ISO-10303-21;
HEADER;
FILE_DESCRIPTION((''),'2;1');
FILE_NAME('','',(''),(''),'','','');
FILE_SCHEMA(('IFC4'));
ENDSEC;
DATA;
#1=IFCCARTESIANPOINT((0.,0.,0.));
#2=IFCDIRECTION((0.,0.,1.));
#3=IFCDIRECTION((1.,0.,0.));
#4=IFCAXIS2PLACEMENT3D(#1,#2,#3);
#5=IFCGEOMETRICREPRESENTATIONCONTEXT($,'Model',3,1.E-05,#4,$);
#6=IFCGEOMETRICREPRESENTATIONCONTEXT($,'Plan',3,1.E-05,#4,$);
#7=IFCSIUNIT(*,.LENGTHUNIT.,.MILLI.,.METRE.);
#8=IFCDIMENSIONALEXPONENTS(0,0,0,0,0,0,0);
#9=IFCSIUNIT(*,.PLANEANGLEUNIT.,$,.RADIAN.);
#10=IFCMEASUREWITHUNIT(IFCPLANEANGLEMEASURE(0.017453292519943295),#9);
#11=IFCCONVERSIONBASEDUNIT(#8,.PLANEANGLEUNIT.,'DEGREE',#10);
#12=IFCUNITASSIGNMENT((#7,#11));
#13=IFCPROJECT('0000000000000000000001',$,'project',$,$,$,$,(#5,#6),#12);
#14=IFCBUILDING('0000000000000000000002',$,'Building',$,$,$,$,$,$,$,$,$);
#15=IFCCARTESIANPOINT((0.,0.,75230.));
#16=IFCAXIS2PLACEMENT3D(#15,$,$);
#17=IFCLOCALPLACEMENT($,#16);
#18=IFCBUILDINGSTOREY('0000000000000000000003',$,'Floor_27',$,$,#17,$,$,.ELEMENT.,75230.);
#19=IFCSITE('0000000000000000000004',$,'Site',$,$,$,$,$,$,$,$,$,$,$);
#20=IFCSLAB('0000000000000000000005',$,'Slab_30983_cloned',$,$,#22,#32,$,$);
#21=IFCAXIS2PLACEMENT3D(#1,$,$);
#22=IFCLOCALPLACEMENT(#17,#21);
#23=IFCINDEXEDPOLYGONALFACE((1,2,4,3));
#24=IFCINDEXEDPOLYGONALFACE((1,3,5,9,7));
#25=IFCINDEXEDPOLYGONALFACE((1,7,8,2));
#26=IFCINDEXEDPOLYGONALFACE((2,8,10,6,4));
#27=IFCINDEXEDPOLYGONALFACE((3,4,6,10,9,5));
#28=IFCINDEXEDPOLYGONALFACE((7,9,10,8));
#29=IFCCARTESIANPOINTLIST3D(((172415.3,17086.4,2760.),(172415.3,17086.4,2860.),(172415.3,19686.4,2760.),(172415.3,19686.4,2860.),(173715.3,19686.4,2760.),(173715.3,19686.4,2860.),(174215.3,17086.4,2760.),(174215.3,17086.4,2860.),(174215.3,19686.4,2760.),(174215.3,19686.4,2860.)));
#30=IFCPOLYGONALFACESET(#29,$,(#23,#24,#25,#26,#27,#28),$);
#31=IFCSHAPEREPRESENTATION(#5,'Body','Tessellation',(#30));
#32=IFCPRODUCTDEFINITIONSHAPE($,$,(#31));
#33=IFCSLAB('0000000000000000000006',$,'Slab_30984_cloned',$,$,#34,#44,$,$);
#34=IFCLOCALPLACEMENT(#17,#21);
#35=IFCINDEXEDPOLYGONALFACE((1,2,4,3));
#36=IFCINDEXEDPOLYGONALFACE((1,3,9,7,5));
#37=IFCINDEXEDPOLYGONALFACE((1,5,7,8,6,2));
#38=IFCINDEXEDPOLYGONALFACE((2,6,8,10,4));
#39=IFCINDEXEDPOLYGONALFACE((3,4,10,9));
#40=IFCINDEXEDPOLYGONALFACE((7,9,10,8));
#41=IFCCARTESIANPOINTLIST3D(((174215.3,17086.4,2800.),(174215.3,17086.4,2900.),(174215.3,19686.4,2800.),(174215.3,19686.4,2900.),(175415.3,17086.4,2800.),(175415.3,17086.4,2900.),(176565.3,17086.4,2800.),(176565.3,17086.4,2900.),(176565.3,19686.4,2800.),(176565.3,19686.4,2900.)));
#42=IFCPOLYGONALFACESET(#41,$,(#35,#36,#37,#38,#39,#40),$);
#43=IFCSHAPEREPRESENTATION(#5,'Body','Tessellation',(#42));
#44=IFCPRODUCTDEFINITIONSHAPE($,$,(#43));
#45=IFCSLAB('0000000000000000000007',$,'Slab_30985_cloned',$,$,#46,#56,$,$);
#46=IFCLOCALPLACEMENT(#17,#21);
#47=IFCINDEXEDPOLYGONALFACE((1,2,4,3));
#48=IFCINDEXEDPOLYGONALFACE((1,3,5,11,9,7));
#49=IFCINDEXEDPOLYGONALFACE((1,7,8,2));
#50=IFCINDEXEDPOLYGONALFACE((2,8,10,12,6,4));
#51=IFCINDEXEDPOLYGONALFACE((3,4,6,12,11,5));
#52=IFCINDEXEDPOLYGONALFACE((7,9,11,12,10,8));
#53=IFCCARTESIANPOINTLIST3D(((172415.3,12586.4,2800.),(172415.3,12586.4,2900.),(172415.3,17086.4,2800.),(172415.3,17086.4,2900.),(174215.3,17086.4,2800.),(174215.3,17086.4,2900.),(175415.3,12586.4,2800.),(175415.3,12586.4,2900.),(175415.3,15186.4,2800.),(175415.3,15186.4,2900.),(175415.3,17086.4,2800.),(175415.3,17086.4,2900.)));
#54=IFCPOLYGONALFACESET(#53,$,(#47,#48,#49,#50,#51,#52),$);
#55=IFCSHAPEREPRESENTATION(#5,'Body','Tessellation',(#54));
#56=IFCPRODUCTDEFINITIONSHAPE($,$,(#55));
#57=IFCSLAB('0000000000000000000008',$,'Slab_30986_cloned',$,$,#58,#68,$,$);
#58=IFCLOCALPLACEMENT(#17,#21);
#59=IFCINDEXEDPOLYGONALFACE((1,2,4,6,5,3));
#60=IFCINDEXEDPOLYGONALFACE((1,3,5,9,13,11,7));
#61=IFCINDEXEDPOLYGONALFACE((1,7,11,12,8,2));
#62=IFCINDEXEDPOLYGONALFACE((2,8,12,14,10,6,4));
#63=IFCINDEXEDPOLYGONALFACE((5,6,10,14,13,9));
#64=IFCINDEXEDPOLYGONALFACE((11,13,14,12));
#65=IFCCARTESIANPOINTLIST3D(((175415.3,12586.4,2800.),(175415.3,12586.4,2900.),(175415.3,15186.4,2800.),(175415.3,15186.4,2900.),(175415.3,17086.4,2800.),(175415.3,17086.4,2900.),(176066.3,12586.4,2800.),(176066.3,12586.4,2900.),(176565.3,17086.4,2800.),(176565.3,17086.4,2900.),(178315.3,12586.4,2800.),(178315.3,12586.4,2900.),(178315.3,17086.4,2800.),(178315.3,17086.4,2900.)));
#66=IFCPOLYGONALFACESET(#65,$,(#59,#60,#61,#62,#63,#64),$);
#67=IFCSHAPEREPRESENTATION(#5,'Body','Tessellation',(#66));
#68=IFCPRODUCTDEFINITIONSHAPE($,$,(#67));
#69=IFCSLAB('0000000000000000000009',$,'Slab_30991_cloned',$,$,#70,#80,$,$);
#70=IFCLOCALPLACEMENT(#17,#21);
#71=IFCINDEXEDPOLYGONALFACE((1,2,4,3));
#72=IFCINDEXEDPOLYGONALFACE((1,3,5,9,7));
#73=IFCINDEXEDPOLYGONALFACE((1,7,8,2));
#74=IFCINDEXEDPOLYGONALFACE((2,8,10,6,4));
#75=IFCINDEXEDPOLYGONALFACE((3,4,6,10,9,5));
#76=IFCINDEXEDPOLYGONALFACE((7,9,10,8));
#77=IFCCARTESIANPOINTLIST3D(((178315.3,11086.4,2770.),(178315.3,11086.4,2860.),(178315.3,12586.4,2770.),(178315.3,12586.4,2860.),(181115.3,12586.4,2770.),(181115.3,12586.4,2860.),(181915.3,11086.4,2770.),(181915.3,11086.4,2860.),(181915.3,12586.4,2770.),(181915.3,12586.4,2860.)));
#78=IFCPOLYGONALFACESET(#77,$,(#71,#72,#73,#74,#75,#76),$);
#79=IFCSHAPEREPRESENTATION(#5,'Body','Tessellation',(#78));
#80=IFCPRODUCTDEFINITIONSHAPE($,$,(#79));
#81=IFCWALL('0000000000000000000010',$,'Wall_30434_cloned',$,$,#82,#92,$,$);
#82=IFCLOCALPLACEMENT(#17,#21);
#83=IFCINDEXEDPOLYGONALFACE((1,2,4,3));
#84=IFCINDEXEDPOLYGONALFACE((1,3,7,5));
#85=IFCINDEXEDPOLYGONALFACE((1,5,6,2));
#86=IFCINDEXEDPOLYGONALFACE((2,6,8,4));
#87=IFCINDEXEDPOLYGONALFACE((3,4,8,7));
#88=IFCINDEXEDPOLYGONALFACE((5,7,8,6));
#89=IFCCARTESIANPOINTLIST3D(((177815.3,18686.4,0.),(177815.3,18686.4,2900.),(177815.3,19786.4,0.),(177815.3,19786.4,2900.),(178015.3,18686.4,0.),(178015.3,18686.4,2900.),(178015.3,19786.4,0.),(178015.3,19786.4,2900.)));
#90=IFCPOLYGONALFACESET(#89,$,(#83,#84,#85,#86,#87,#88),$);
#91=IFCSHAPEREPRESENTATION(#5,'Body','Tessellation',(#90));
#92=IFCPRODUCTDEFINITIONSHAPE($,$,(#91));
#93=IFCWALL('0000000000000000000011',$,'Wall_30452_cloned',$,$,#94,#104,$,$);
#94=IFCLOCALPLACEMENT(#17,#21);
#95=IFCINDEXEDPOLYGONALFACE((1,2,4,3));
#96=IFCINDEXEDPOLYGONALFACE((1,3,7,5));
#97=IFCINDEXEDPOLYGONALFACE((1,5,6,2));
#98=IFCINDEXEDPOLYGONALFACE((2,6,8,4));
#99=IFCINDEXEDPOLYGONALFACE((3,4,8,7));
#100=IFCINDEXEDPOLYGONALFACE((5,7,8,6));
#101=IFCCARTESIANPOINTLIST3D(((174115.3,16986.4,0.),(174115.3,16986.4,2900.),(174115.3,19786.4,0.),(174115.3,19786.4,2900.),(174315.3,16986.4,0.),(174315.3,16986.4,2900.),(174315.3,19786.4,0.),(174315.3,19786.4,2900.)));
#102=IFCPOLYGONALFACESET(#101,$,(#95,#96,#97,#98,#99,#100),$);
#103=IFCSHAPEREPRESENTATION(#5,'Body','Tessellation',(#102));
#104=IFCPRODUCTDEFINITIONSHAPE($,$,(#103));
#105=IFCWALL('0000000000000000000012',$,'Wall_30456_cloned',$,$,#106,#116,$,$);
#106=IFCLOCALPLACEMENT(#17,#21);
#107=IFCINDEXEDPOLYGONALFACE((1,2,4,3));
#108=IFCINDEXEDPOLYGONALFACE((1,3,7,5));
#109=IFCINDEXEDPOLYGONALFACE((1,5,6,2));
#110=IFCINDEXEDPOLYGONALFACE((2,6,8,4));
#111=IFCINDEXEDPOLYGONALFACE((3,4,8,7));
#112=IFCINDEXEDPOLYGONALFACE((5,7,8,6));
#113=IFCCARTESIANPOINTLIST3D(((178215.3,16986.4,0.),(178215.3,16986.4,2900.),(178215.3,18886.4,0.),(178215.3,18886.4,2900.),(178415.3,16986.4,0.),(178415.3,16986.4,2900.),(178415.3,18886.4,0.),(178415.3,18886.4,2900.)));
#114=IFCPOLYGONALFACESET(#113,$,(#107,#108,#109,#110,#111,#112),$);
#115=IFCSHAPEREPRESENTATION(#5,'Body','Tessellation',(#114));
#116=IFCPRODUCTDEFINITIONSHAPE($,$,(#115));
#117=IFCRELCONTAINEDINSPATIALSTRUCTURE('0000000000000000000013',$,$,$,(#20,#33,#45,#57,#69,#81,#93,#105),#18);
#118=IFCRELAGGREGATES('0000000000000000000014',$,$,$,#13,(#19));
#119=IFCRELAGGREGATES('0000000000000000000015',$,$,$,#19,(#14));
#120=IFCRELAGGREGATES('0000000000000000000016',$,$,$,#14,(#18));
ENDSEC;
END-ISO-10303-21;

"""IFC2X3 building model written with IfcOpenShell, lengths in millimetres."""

from ifc_helpers import new_model, entity, si_unit, converted_unit, frame, origin_with_axes, origin_2d, place, context, project, spatial, polyline, rectangle, outline, extrude, source, transform, mapped, element, save


model = new_model("IFC2X3")

# Units and contexts
model_context = context("Model", 3, precision=1e-05, world=origin_with_axes())
plan_context = context("Plan", 3, precision=1e-05, world=origin_with_axes())
ifc_project = project(units=[si_unit("LENGTHUNIT", "METRE", prefix="MILLI"), converted_unit("PLANEANGLEUNIT", "DEGREE", entity("IfcPlaneAngleMeasure", 0.017453292519943295), si_unit("PLANEANGLEUNIT", "RADIAN"), dimensions=[0, 0, 0, 0, 0, 0, 0])], contexts=[model_context, plan_context])

# Site, building, storey
site = spatial("IfcSite", under=ifc_project, Name="Site")
building = spatial("IfcBuilding", under=site, Name="Building")
storey_placement = place(None, frame((0.0, 0.0, 75230.0)))
storey = spatial("IfcBuildingStorey", under=building, at=storey_placement, Name="Floor_27", CompositionType="ELEMENT", Elevation=75230.0)

# Slabs
shared_shape_1 = source(origin_with_axes(), model_context, "Body", "SweptSolid", [
    extrude(outline(polyline([(0.0, 0.0), (2600.0, 0.0), (2600.0, 1800.0), (0.0, 1800.0), (0.0, 1300.0)])), origin_with_axes(), (0.0, 0.0, 1.0), 100.0),
])
slab_1_placement = place(storey_placement, frame((172415.3, 19686.4, 2760.0), z_axis=(0.0, 0.0, 1.0), x_axis=(0.0, -2599.99, 0.0)))
element("IfcSlab", 1, at=slab_1_placement, inside=storey, Name="Slab_30983_cloned", context=model_context, shape_type="MappedRepresentation", body=[
    mapped(shared_shape_1, transform((0.0, 0.0, 0.0), x_axis=(1.0, 0.0, 0.0), y_axis=(0.0, 1.0, 0.0), z_axis=(0.0, 0.0, 1.0), scale=1.0)),
])
shared_shape_2 = source(origin_with_axes(), model_context, "Body", "SweptSolid", [
    extrude(outline(polyline([(0.0, 0.0), (2600.0, 0.0), (2600.0, 1200.0), (2600.0, 2350.0), (0.0, 2350.0)])), origin_with_axes(), (0.0, 0.0, 1.0), 100.0),
])
slab_2_placement = place(storey_placement, frame((174215.3, 19686.4, 2800.0), z_axis=(0.0, 0.0, 1.0), x_axis=(0.0, -2599.99, 0.0)))
element("IfcSlab", 2, at=slab_2_placement, inside=storey, Name="Slab_30984_cloned", context=model_context, shape_type="MappedRepresentation", body=[
    mapped(shared_shape_2, transform((0.0, 0.0, 0.0), x_axis=(1.0, 0.0, 0.0), y_axis=(0.0, 1.0, 0.0), z_axis=(0.0, 0.0, 1.0), scale=1.0)),
])
shared_shape_3 = source(origin_with_axes(), model_context, "Body", "SweptSolid", [
    extrude(outline(polyline([(0.0, 0.0), (4500.0, 0.0), (4500.0, 3000.0), (1900.0, 3000.0), (0.0, 3000.0), (0.0, 1800.0)])), origin_with_axes(), (0.0, 0.0, 1.0), 100.0),
])
slab_3_placement = place(storey_placement, frame((172415.3, 17086.4, 2800.0), z_axis=(0.0, 0.0, 1.0), x_axis=(0.0, -4500.031, 0.0)))
element("IfcSlab", 3, at=slab_3_placement, inside=storey, Name="Slab_30985_cloned", context=model_context, shape_type="MappedRepresentation", body=[
    mapped(shared_shape_3, transform((0.0, 0.0, 0.0), x_axis=(1.0, 0.0, 0.0), y_axis=(0.0, 1.0, 0.0), z_axis=(0.0, 0.0, 1.0), scale=1.0)),
])
shared_shape_4 = source(origin_with_axes(), model_context, "Body", "SweptSolid", [
    extrude(outline(polyline([(0.0, 0.0), (1900.0, 0.0), (4500.0, 0.0), (4500.0, 651.0), (4500.0, 2900.0), (0.0, 2900.0), (0.0, 1150.0)])), origin_with_axes(), (0.0, 0.0, 1.0), 100.0),
])
slab_4_placement = place(storey_placement, frame((175415.3, 17086.4, 2800.0), z_axis=(0.0, 0.0, 1.0), x_axis=(-0.006, -1900.025, 0.0)))
element("IfcSlab", 4, at=slab_4_placement, inside=storey, Name="Slab_30986_cloned", context=model_context, shape_type="MappedRepresentation", body=[
    mapped(shared_shape_4, transform((0.0, 0.0, 0.0), x_axis=(1.0, 0.0, 0.0), y_axis=(0.0, 1.0, 0.0), z_axis=(0.0, 0.0, 1.0), scale=1.0)),
])
shared_shape_5 = source(origin_with_axes(), model_context, "Body", "SweptSolid", [
    extrude(outline(polyline([(0.0, 0.0), (1500.0, 0.0), (1500.0, 3600.0), (0.0, 3600.0), (0.0, 2800.0)])), origin_with_axes(), (0.0, 0.0, 1.0), 90.0),
])
slab_5_placement = place(storey_placement, frame((178315.3, 12586.4, 2770.0), z_axis=(0.0, 0.0, 1.0), x_axis=(0.0, -1500.0, 0.0)))
element("IfcSlab", 5, at=slab_5_placement, inside=storey, Name="Slab_30991_cloned", context=model_context, shape_type="MappedRepresentation", body=[
    mapped(shared_shape_5, transform((0.0, 0.0, 0.0), x_axis=(1.0, 0.0, 0.0), y_axis=(0.0, 1.0, 0.0), z_axis=(0.0, 0.0, 1.0), scale=1.0)),
])

# Walls
shared_shape_6 = source(origin_with_axes(), model_context, "Body", "SweptSolid", [
    extrude(rectangle(XDim=1100.0, YDim=200.0, at=origin_2d()), origin_with_axes(), (0.0, 0.0, 1.0), 2900.0),
])
wall_1_placement = place(storey_placement, frame((177915.3, 19236.4, 0.0), z_axis=(0.0, 0.0, 1.0), x_axis=(0.000094, 1099.995689, 0.0)))
element("IfcWall", 6, at=wall_1_placement, inside=storey, Name="Wall_30434_cloned", context=model_context, shape_type="MappedRepresentation", body=[
    mapped(shared_shape_6, transform((0.0, 0.0, 0.0), x_axis=(1.0, 0.0, 0.0), y_axis=(0.0, 1.0, 0.0), z_axis=(0.0, 0.0, 1.0), scale=1.0)),
])
shared_shape_7 = source(origin_with_axes(), model_context, "Body", "SweptSolid", [
    extrude(rectangle(XDim=2800.0, YDim=200.0, at=origin_2d()), origin_with_axes(), (0.0, 0.0, 1.0), 2900.0),
])
wall_2_placement = place(storey_placement, frame((174215.3, 18386.4, 0.0), z_axis=(0.0, 0.0, 1.0), x_axis=(0.0, 2799.990212, 0.0)))
element("IfcWall", 7, at=wall_2_placement, inside=storey, Name="Wall_30452_cloned", context=model_context, shape_type="MappedRepresentation", body=[
    mapped(shared_shape_7, transform((0.0, 0.0, 0.0), x_axis=(1.0, 0.0, 0.0), y_axis=(0.0, 1.0, 0.0), z_axis=(0.0, 0.0, 1.0), scale=1.0)),
])
shared_shape_8 = source(origin_with_axes(), model_context, "Body", "SweptSolid", [
    extrude(rectangle(XDim=1900.0, YDim=200.0, at=origin_2d()), origin_with_axes(), (0.0, 0.0, 1.0), 2900.0),
])
wall_3_placement = place(storey_placement, frame((178315.3, 17936.4, 0.0), z_axis=(0.0, 0.0, 1.0), x_axis=(0.000403, 1899.988898, 0.0)))
element("IfcWall", 8, at=wall_3_placement, inside=storey, Name="Wall_30456_cloned", context=model_context, shape_type="MappedRepresentation", body=[
    mapped(shared_shape_8, transform((0.0, 0.0, 0.0), x_axis=(1.0, 0.0, 0.0), y_axis=(0.0, 1.0, 0.0), z_axis=(0.0, 0.0, 1.0), scale=1.0)),
])

save(model, "model.ifc")
